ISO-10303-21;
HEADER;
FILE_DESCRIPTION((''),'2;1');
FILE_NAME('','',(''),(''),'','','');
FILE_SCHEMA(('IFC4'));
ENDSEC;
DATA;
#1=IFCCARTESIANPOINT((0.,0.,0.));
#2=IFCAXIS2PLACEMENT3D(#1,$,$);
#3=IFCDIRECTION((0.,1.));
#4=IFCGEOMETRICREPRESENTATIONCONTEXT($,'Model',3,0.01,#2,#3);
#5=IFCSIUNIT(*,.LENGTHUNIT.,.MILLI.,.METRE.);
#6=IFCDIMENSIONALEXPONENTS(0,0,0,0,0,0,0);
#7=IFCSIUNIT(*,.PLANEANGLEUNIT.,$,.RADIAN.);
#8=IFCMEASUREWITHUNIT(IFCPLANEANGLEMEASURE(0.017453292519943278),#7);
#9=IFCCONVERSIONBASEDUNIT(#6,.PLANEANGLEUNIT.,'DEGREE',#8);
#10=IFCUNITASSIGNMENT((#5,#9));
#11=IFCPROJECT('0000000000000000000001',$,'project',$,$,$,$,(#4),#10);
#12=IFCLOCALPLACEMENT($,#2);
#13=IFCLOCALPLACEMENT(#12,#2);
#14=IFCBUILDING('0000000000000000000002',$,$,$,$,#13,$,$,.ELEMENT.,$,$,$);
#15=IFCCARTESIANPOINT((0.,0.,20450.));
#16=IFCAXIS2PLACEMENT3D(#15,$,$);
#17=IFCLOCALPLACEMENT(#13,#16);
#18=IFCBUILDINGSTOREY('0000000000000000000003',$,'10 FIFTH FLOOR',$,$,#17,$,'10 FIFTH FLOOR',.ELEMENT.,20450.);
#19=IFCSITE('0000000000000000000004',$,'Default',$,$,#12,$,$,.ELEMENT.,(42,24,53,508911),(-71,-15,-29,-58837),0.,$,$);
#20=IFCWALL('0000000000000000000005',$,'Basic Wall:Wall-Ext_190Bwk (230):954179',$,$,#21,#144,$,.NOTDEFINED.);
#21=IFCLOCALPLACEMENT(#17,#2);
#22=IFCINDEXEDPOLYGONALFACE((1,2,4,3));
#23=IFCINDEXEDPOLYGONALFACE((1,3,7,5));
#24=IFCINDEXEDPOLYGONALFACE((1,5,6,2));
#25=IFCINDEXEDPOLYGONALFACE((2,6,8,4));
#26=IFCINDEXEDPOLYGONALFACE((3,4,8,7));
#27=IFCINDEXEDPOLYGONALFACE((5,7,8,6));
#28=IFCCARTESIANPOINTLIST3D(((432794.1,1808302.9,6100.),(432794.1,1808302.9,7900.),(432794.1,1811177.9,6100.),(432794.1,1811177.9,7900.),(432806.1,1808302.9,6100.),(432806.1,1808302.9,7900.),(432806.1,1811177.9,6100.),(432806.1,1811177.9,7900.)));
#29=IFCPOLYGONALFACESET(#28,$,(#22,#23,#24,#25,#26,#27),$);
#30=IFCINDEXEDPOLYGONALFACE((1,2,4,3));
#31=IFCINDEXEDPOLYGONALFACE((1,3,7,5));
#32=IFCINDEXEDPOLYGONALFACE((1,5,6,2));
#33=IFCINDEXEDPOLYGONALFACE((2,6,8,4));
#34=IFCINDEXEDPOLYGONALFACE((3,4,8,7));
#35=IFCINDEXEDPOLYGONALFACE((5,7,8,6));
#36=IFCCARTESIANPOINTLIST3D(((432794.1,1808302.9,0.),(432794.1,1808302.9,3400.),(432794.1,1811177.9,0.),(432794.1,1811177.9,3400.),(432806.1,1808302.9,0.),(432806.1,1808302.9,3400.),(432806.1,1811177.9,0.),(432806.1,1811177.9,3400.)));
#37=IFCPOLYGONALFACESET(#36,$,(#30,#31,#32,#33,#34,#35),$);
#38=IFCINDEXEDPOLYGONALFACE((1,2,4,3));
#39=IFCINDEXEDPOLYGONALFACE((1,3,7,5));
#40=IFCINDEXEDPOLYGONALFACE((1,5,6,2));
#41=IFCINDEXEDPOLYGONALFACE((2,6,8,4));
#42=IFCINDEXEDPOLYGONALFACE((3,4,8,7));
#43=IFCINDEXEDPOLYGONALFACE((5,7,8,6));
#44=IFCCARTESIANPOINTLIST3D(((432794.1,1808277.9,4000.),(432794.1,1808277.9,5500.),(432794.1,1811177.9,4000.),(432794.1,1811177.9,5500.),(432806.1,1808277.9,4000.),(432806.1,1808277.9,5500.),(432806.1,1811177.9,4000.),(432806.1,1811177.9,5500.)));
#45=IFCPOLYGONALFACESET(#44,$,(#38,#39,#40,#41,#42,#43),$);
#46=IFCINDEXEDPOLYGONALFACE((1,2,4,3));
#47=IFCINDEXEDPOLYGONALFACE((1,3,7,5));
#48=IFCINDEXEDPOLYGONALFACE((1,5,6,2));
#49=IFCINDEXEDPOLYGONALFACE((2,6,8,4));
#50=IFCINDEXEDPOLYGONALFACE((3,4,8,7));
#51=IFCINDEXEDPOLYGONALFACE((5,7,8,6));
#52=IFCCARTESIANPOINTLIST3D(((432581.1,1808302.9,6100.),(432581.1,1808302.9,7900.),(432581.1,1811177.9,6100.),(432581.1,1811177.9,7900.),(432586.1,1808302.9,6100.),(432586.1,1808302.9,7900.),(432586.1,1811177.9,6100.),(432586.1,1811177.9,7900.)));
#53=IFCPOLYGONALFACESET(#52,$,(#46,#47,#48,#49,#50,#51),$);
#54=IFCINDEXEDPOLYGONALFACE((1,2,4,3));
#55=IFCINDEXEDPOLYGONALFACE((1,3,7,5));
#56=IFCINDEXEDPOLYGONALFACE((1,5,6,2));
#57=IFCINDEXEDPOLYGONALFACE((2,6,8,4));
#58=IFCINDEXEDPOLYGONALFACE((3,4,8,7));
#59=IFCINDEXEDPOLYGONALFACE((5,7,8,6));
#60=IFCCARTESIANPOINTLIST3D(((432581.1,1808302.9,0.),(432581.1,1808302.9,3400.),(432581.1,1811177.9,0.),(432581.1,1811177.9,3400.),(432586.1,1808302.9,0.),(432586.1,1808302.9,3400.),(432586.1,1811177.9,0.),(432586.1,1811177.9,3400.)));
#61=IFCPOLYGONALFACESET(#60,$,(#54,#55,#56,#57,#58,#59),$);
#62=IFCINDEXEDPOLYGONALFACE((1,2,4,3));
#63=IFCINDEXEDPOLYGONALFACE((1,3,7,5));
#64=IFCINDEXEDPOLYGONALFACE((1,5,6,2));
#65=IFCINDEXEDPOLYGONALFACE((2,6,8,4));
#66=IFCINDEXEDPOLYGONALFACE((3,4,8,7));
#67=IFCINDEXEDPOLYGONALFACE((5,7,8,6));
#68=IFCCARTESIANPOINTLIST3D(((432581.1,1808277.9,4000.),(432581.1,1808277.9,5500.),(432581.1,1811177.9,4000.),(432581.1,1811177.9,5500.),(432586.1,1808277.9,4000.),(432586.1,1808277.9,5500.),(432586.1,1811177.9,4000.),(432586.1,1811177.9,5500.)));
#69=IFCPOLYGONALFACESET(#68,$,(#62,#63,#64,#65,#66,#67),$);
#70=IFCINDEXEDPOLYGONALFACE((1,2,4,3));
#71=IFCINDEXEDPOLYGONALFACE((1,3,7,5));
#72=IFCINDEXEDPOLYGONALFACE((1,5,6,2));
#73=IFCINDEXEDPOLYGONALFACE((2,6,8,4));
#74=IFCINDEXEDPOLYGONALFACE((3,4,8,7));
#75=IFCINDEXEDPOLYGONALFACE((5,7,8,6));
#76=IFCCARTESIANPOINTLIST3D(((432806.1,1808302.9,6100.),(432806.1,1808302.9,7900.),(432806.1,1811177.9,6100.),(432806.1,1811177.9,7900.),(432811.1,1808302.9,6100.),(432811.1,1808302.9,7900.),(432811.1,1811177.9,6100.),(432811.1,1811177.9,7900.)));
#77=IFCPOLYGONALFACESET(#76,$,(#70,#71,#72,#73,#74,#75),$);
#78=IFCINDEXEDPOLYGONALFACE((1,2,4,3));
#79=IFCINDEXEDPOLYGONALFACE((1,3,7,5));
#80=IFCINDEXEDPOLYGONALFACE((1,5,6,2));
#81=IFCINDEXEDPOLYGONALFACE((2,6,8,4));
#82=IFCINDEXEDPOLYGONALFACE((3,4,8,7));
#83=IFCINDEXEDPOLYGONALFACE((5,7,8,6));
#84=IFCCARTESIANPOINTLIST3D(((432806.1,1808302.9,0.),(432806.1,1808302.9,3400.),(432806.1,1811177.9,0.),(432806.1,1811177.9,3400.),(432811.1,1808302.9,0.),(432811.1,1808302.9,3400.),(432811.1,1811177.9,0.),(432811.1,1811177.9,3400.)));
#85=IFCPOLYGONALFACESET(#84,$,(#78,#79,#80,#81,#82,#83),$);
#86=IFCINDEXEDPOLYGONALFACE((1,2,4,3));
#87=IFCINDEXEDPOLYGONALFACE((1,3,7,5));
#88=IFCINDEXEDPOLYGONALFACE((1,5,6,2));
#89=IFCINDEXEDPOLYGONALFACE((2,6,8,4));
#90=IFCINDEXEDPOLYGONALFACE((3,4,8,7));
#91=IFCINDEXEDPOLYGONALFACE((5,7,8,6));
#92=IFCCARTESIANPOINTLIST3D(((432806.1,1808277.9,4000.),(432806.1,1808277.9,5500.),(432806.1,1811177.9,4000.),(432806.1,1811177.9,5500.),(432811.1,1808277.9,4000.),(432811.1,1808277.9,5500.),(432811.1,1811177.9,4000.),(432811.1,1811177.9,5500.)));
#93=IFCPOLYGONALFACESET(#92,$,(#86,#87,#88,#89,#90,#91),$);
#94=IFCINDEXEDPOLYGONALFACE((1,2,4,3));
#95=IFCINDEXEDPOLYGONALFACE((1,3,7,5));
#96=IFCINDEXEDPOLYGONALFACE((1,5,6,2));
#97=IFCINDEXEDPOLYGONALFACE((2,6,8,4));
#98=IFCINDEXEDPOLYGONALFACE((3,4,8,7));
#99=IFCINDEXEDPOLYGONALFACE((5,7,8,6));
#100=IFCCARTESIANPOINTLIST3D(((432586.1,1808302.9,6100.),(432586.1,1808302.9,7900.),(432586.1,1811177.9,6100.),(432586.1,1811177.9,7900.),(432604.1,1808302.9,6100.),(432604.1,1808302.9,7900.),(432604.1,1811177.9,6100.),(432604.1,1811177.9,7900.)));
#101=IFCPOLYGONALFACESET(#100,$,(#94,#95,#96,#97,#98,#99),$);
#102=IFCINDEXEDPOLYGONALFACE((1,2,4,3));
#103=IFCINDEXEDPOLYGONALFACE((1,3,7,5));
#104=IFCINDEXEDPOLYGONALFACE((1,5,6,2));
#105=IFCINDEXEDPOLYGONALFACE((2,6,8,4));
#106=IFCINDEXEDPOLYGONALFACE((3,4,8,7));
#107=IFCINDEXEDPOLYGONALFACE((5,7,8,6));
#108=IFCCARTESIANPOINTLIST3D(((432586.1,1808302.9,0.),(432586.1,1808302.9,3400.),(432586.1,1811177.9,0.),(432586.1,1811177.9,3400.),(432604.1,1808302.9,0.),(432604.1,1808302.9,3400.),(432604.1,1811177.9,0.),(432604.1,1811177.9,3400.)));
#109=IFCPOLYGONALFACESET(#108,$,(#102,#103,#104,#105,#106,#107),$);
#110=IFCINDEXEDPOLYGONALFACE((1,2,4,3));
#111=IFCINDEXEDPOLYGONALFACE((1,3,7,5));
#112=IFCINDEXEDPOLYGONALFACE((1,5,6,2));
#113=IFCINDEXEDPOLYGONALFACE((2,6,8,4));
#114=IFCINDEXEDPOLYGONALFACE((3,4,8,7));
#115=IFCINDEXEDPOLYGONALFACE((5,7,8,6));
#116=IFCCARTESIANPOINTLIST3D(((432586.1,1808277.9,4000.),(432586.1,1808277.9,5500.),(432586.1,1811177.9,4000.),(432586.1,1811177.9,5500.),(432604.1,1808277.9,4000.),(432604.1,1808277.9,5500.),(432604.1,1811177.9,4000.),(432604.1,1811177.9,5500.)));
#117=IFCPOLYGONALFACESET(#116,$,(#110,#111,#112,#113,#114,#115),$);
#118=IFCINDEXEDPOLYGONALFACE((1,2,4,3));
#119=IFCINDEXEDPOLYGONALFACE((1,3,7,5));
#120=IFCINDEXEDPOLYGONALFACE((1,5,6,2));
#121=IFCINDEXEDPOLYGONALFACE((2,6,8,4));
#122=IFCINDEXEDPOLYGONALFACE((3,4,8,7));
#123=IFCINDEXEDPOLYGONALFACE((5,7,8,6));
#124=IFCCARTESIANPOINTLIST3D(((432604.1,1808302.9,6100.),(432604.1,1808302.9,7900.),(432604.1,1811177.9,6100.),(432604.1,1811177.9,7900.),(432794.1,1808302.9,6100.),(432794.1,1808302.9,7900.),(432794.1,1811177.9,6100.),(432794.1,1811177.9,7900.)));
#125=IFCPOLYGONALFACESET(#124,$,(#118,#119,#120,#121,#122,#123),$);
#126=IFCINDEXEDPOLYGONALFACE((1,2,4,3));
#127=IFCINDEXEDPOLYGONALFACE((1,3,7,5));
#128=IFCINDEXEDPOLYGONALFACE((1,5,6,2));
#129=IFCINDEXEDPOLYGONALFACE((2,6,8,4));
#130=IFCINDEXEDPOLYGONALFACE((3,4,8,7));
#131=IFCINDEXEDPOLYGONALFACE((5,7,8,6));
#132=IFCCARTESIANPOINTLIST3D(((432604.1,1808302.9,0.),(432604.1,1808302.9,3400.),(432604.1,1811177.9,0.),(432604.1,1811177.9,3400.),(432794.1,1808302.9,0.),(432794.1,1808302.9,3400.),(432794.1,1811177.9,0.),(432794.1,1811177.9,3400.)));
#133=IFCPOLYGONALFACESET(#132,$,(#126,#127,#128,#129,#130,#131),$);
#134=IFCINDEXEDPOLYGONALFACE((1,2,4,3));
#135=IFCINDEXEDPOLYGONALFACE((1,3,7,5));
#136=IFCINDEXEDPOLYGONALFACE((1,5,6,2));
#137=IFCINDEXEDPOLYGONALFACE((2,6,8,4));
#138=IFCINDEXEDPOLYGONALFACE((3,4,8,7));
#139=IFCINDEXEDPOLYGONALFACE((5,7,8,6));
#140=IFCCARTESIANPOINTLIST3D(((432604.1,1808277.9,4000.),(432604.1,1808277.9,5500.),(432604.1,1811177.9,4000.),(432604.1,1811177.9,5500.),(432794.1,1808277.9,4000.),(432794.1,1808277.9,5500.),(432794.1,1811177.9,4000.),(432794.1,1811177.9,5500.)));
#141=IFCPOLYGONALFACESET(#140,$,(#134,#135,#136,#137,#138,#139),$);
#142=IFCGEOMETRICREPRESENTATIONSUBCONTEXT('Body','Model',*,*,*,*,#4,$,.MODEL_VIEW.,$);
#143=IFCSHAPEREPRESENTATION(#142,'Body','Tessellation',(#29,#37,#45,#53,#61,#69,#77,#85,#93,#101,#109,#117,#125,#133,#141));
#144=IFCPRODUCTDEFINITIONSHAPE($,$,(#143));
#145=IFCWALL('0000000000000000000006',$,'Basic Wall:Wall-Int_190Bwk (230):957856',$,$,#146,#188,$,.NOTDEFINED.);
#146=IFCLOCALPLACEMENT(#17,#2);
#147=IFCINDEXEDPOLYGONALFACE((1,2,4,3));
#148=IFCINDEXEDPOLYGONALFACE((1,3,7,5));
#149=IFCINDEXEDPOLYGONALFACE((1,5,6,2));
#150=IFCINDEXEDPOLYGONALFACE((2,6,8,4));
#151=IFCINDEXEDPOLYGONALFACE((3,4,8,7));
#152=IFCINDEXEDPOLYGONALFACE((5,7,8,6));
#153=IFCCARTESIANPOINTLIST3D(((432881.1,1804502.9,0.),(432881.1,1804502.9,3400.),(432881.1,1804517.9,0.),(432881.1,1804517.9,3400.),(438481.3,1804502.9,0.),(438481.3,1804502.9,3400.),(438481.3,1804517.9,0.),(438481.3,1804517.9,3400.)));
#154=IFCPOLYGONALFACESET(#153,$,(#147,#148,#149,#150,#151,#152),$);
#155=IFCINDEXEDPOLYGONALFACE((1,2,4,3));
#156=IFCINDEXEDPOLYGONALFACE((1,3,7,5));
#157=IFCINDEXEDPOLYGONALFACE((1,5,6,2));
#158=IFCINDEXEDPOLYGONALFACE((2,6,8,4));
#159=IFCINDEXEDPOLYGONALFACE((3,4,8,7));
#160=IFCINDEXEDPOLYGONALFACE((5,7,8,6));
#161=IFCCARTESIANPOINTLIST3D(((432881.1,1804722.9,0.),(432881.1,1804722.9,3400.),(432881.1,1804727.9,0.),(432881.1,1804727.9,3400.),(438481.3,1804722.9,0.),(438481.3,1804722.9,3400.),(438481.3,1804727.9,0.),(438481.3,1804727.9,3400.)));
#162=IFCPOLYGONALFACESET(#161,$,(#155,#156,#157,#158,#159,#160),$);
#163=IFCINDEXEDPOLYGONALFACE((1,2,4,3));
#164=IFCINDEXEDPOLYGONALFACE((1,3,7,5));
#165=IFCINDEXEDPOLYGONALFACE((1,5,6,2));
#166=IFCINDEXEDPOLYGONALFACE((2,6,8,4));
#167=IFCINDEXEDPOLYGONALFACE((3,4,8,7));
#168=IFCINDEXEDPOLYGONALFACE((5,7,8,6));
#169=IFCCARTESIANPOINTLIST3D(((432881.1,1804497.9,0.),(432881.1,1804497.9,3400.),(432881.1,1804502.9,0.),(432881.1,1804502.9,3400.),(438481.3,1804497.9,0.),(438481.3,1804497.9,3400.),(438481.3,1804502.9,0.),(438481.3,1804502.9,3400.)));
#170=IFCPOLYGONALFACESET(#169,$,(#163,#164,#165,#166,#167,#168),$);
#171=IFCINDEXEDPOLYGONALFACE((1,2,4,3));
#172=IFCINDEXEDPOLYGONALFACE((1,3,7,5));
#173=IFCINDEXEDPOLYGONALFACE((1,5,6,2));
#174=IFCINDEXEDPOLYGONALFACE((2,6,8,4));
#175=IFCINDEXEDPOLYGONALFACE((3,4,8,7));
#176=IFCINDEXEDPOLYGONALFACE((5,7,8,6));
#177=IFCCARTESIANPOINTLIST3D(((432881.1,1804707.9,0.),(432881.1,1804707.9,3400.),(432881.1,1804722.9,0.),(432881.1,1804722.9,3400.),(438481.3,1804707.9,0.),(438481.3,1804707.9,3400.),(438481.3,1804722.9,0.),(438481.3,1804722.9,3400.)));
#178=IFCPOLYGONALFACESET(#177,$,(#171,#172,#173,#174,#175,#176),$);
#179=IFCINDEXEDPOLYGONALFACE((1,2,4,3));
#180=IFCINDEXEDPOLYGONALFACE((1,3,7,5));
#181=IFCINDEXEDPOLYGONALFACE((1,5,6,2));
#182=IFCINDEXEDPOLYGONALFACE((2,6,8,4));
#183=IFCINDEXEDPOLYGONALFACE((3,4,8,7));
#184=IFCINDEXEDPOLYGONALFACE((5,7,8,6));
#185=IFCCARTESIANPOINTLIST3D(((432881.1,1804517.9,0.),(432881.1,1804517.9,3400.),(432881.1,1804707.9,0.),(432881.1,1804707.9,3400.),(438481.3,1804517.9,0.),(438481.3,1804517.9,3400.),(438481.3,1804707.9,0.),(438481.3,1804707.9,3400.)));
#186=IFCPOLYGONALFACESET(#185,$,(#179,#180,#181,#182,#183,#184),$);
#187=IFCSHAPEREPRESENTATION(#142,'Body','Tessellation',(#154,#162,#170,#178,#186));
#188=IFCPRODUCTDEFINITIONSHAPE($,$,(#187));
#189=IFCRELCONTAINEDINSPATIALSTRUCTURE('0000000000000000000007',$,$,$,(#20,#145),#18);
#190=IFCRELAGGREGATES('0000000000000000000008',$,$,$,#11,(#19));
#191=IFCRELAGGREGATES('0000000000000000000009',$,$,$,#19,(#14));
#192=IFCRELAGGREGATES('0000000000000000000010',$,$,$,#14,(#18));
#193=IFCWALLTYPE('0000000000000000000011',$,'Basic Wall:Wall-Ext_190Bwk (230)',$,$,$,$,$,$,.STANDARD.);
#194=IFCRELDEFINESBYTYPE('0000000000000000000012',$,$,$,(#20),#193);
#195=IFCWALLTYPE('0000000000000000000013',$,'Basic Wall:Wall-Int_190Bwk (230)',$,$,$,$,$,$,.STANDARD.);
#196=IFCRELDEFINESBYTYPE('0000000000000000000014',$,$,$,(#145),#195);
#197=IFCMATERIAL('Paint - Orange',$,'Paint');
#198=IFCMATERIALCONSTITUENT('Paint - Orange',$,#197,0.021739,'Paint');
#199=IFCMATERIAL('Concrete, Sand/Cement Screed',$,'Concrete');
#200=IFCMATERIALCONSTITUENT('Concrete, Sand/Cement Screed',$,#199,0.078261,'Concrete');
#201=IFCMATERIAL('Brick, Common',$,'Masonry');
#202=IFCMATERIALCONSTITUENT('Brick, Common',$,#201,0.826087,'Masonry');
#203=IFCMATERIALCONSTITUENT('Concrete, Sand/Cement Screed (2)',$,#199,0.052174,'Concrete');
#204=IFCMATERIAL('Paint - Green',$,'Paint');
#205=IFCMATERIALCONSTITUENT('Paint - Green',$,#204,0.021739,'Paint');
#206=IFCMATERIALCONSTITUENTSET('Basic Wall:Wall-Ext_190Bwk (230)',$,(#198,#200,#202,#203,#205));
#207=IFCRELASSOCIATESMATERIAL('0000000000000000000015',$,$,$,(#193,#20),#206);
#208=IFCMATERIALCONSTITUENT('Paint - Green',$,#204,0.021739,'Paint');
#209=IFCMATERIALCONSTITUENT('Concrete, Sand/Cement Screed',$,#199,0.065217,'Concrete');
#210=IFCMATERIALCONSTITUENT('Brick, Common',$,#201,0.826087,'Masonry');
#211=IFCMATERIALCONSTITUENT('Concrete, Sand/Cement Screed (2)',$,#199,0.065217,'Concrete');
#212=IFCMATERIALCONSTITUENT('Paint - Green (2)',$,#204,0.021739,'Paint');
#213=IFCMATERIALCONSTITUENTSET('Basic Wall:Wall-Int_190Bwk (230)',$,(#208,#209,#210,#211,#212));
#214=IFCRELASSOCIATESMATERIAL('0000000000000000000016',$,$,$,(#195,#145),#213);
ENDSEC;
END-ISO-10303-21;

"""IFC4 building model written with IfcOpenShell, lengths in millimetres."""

from ifc_helpers import new_model, entity, si_unit, converted_unit, direction, frame, origin, place, context, subcontext, project, spatial, indexed_curve, outline, extrude, material, constituent, constituent_set, type_object, element, save


model = new_model("IFC4")

# Units and contexts
model_context = context("Model", 3, precision=0.01, world=origin(), true_north=direction((0.0, 1.0)))
body_context = subcontext(model_context, "Body", "Model", "MODEL_VIEW")
ifc_project = project(units=[si_unit("LENGTHUNIT", "METRE", prefix="MILLI"), converted_unit("PLANEANGLEUNIT", "DEGREE", entity("IfcPlaneAngleMeasure", 0.017453292519943278), si_unit("PLANEANGLEUNIT", "RADIAN"), dimensions=[0, 0, 0, 0, 0, 0, 0])], contexts=[model_context])

# Site, building, storey
site_placement = place(None, origin())
site = spatial("IfcSite", under=ifc_project, at=site_placement, Name="Default", CompositionType="ELEMENT", RefLatitude=(42, 24, 53, 508911), RefLongitude=(-71, -15, -29, -58837), RefElevation=0.0)
building_placement = place(site_placement, origin())
building = spatial("IfcBuilding", under=site, at=building_placement, CompositionType="ELEMENT")
storey_placement = place(building_placement, frame((0.0, 0.0, 20450.0)))
storey = spatial("IfcBuildingStorey", under=building, at=storey_placement, Name="10 FIFTH FLOOR", LongName="10 FIFTH FLOOR", CompositionType="ELEMENT", Elevation=20450.0)

# Shared definitions
ifc_material_1 = material(Name="Concrete, Sand/Cement Screed", Category="Concrete")
ifc_material_2 = material(Name="Brick, Common", Category="Masonry")

# Shared definitions
ifc_material_3 = material(Name="Paint - Orange", Category="Paint")
ifc_constituent_1 = constituent(ifc_material_3, Name="Paint - Orange", Category="Paint", fraction=0.021739)
ifc_constituent_2 = constituent(ifc_material_1, Name="Concrete, Sand/Cement Screed", Category="Concrete", fraction=0.078261)
ifc_constituent_3 = constituent(ifc_material_2, Name="Brick, Common", Category="Masonry", fraction=0.826087)
ifc_constituent_4 = constituent(ifc_material_1, Name="Concrete, Sand/Cement Screed (2)", Category="Concrete", fraction=0.052174)
ifc_material_4 = material(Name="Paint - Green", Category="Paint")
ifc_constituent_5 = constituent(ifc_material_4, Name="Paint - Green", Category="Paint", fraction=0.021739)
ifc_constituent_set_1 = constituent_set(constituents=[ifc_constituent_1, ifc_constituent_2, ifc_constituent_3, ifc_constituent_4, ifc_constituent_5], Name="Basic Wall:Wall-Ext_190Bwk (230)")
wall_type_1 = type_object("IfcWallType", Name="Basic Wall:Wall-Ext_190Bwk (230)", PredefinedType="STANDARD", material=ifc_constituent_set_1)

# Walls
wall_1_placement = place(storey_placement, frame((432696.1, 1808277.9, 0.0), z_axis=(0.0, 0.0, 1.0), x_axis=(0.0, 1.0, 0.0)))
element("IfcWall", 1, at=wall_1_placement, inside=storey, type_object=wall_type_1, material=ifc_constituent_set_1, Name="Basic Wall:Wall-Ext_190Bwk (230):954179", PredefinedType="NOTDEFINED", context=body_context, shape_type="SweptSolid", body=[
    extrude(outline(indexed_curve([(-1437.5, -6.0), (1437.5, -6.0), (1437.5, 6.0), (-1437.5, 6.0), (-1437.5, -6.0)], self_intersect=False)), frame((1462.5, -104.0, 6100.0), z_axis=(0.0, 0.0, 1.0), x_axis=(-1.0, 0.0, 0.0)), (0.0, 0.0, 1.0), 1800.0),
    extrude(outline(indexed_curve([(-1437.5, -6.0), (1437.5, -6.0), (1437.5, 6.0), (-1437.5, 6.0), (-1437.5, -6.0)], self_intersect=False)), frame((1462.5, -104.0, 0.0)), (0.0, 0.0, 1.0), 3400.0),
    extrude(outline(indexed_curve([(-1450.0, -6.0), (1450.0, -6.0), (1450.0, 6.0), (-1450.0, 6.0), (-1450.0, -6.0)], self_intersect=False)), frame((1450.0, -104.0, 4000.0)), (0.0, 0.0, 1.0), 1500.0),
    extrude(outline(indexed_curve([(-2.5, -1437.5), (2.5, -1437.5), (2.5, 1437.5), (-2.5, 1437.5), (-2.5, -1437.5)], self_intersect=False)), frame((1462.5, 112.5, 6100.0), z_axis=(0.0, 0.0, 1.0), x_axis=(0.0, -1.0, 0.0)), (0.0, 0.0, 1.0), 1800.0),
    extrude(outline(indexed_curve([(-2.5, -1437.5), (2.5, -1437.5), (2.5, 1437.5), (-2.5, 1437.5), (-2.5, -1437.5)], self_intersect=False)), frame((1462.5, 112.5, 0.0), z_axis=(0.0, 0.0, 1.0), x_axis=(0.0, -1.0, 0.0)), (0.0, 0.0, 1.0), 3400.0),
    extrude(outline(indexed_curve([(-2.5, -1450.0), (2.5, -1450.0), (2.5, 1450.0), (-2.5, 1450.0), (-2.5, -1450.0)], self_intersect=False)), frame((1450.0, 112.5, 4000.0), z_axis=(0.0, 0.0, 1.0), x_axis=(0.0, -1.0, 0.0)), (0.0, 0.0, 1.0), 1500.0),
    extrude(outline(indexed_curve([(-2.5, -1437.5), (2.5, -1437.5), (2.5, 1437.5), (-2.5, 1437.5), (-2.5, -1437.5)], self_intersect=False)), frame((1462.5, -112.5, 6100.0), z_axis=(0.0, 0.0, 1.0), x_axis=(0.0, 1.0, 0.0)), (0.0, 0.0, 1.0), 1800.0),
    extrude(outline(indexed_curve([(-2.5, -1437.5), (2.5, -1437.5), (2.5, 1437.5), (-2.5, 1437.5), (-2.5, -1437.5)], self_intersect=False)), frame((1462.5, -112.5, 0.0), z_axis=(0.0, 0.0, 1.0), x_axis=(0.0, 1.0, 0.0)), (0.0, 0.0, 1.0), 3400.0),
    extrude(outline(indexed_curve([(-2.5, -1450.0), (2.5, -1450.0), (2.5, 1450.0), (-2.5, 1450.0), (-2.5, -1450.0)], self_intersect=False)), frame((1450.0, -112.5, 4000.0), z_axis=(0.0, 0.0, 1.0), x_axis=(0.0, 1.0, 0.0)), (0.0, 0.0, 1.0), 1500.0),
    extrude(outline(indexed_curve([(-1437.5, -9.0), (1437.5, -9.0), (1437.5, 9.0), (-1437.5, 9.0), (-1437.5, -9.0)], self_intersect=False)), frame((1462.5, 101.0, 6100.0), z_axis=(0.0, 0.0, 1.0), x_axis=(-1.0, 0.0, 0.0)), (0.0, 0.0, 1.0), 1800.0),
    extrude(outline(indexed_curve([(-1437.5, -9.0), (1437.5, -9.0), (1437.5, 9.0), (-1437.5, 9.0), (-1437.5, -9.0)], self_intersect=False)), frame((1462.5, 101.0, 0.0)), (0.0, 0.0, 1.0), 3400.0),
    extrude(outline(indexed_curve([(-1450.0, -9.0), (1450.0, -9.0), (1450.0, 9.0), (-1450.0, 9.0), (-1450.0, -9.0)], self_intersect=False)), frame((1450.0, 101.0, 4000.0)), (0.0, 0.0, 1.0), 1500.0),
    extrude(outline(indexed_curve([(-1437.5, -95.0), (1437.5, -95.0), (1437.5, 95.0), (-1437.5, 95.0), (-1437.5, -95.0)], self_intersect=False)), frame((1462.5, -3.0, 6100.0), z_axis=(0.0, 0.0, 1.0), x_axis=(-1.0, 0.0, 0.0)), (0.0, 0.0, 1.0), 1800.0),
    extrude(outline(indexed_curve([(-1437.5, -95.0), (1437.5, -95.0), (1437.5, 95.0), (-1437.5, 95.0), (-1437.5, -95.0)], self_intersect=False)), frame((1462.5, -3.0, 0.0)), (0.0, 0.0, 1.0), 3400.0),
    extrude(outline(indexed_curve([(-1450.0, -95.0), (1450.0, -95.0), (1450.0, 95.0), (-1450.0, 95.0), (-1450.0, -95.0)], self_intersect=False)), frame((1450.0, -3.0, 4000.0)), (0.0, 0.0, 1.0), 1500.0),
])
ifc_constituent_6 = constituent(ifc_material_4, Name="Paint - Green", Category="Paint", fraction=0.021739)
ifc_constituent_7 = constituent(ifc_material_1, Name="Concrete, Sand/Cement Screed", Category="Concrete", fraction=0.065217)
ifc_constituent_8 = constituent(ifc_material_2, Name="Brick, Common", Category="Masonry", fraction=0.826087)
ifc_constituent_9 = constituent(ifc_material_1, Name="Concrete, Sand/Cement Screed (2)", Category="Concrete", fraction=0.065217)
ifc_constituent_10 = constituent(ifc_material_4, Name="Paint - Green (2)", Category="Paint", fraction=0.021739)
ifc_constituent_set_2 = constituent_set(constituents=[ifc_constituent_6, ifc_constituent_7, ifc_constituent_8, ifc_constituent_9, ifc_constituent_10], Name="Basic Wall:Wall-Int_190Bwk (230)")
wall_type_2 = type_object("IfcWallType", Name="Basic Wall:Wall-Int_190Bwk (230)", PredefinedType="STANDARD", material=ifc_constituent_set_2)
wall_2_placement = place(storey_placement, frame((432881.1, 1804612.9, 0.0)))
element("IfcWall", 2, at=wall_2_placement, inside=storey, type_object=wall_type_2, material=ifc_constituent_set_2, Name="Basic Wall:Wall-Int_190Bwk (230):957856", PredefinedType="NOTDEFINED", context=body_context, shape_type="SweptSolid", body=[
    extrude(outline(indexed_curve([(-2800.1, -7.5), (2800.1, -7.5), (2800.1, 7.5), (-2800.1, 7.5), (-2800.1, -7.5)], self_intersect=False)), frame((2800.1, -102.5, 0.0)), (0.0, 0.0, 1.0), 3400.0),
    extrude(outline(indexed_curve([(-2.5, -2800.1), (2.5, -2800.1), (2.5, 2800.1), (-2.5, 2800.1), (-2.5, -2800.1)], self_intersect=False)), frame((2800.1, 112.5, 0.0), z_axis=(0.0, 0.0, 1.0), x_axis=(0.0, -1.0, 0.0)), (0.0, 0.0, 1.0), 3400.0),
    extrude(outline(indexed_curve([(-2.5, -2800.1), (2.5, -2800.1), (2.5, 2800.1), (-2.5, 2800.1), (-2.5, -2800.1)], self_intersect=False)), frame((2800.1, -112.5, 0.0), z_axis=(0.0, 0.0, 1.0), x_axis=(0.0, 1.0, 0.0)), (0.0, 0.0, 1.0), 3400.0),
    extrude(outline(indexed_curve([(-2800.1, -7.5), (2800.1, -7.5), (2800.1, 7.5), (-2800.1, 7.5), (-2800.1, -7.5)], self_intersect=False)), frame((2800.1, 102.5, 0.0)), (0.0, 0.0, 1.0), 3400.0),
    extrude(outline(indexed_curve([(-2800.1, -95.0), (2800.1, -95.0), (2800.1, 95.0), (-2800.1, 95.0), (-2800.1, -95.0)], self_intersect=False)), frame((2800.1, 0.0, 0.0)), (0.0, 0.0, 1.0), 3400.0),
])

save(model, "model.ifc")
